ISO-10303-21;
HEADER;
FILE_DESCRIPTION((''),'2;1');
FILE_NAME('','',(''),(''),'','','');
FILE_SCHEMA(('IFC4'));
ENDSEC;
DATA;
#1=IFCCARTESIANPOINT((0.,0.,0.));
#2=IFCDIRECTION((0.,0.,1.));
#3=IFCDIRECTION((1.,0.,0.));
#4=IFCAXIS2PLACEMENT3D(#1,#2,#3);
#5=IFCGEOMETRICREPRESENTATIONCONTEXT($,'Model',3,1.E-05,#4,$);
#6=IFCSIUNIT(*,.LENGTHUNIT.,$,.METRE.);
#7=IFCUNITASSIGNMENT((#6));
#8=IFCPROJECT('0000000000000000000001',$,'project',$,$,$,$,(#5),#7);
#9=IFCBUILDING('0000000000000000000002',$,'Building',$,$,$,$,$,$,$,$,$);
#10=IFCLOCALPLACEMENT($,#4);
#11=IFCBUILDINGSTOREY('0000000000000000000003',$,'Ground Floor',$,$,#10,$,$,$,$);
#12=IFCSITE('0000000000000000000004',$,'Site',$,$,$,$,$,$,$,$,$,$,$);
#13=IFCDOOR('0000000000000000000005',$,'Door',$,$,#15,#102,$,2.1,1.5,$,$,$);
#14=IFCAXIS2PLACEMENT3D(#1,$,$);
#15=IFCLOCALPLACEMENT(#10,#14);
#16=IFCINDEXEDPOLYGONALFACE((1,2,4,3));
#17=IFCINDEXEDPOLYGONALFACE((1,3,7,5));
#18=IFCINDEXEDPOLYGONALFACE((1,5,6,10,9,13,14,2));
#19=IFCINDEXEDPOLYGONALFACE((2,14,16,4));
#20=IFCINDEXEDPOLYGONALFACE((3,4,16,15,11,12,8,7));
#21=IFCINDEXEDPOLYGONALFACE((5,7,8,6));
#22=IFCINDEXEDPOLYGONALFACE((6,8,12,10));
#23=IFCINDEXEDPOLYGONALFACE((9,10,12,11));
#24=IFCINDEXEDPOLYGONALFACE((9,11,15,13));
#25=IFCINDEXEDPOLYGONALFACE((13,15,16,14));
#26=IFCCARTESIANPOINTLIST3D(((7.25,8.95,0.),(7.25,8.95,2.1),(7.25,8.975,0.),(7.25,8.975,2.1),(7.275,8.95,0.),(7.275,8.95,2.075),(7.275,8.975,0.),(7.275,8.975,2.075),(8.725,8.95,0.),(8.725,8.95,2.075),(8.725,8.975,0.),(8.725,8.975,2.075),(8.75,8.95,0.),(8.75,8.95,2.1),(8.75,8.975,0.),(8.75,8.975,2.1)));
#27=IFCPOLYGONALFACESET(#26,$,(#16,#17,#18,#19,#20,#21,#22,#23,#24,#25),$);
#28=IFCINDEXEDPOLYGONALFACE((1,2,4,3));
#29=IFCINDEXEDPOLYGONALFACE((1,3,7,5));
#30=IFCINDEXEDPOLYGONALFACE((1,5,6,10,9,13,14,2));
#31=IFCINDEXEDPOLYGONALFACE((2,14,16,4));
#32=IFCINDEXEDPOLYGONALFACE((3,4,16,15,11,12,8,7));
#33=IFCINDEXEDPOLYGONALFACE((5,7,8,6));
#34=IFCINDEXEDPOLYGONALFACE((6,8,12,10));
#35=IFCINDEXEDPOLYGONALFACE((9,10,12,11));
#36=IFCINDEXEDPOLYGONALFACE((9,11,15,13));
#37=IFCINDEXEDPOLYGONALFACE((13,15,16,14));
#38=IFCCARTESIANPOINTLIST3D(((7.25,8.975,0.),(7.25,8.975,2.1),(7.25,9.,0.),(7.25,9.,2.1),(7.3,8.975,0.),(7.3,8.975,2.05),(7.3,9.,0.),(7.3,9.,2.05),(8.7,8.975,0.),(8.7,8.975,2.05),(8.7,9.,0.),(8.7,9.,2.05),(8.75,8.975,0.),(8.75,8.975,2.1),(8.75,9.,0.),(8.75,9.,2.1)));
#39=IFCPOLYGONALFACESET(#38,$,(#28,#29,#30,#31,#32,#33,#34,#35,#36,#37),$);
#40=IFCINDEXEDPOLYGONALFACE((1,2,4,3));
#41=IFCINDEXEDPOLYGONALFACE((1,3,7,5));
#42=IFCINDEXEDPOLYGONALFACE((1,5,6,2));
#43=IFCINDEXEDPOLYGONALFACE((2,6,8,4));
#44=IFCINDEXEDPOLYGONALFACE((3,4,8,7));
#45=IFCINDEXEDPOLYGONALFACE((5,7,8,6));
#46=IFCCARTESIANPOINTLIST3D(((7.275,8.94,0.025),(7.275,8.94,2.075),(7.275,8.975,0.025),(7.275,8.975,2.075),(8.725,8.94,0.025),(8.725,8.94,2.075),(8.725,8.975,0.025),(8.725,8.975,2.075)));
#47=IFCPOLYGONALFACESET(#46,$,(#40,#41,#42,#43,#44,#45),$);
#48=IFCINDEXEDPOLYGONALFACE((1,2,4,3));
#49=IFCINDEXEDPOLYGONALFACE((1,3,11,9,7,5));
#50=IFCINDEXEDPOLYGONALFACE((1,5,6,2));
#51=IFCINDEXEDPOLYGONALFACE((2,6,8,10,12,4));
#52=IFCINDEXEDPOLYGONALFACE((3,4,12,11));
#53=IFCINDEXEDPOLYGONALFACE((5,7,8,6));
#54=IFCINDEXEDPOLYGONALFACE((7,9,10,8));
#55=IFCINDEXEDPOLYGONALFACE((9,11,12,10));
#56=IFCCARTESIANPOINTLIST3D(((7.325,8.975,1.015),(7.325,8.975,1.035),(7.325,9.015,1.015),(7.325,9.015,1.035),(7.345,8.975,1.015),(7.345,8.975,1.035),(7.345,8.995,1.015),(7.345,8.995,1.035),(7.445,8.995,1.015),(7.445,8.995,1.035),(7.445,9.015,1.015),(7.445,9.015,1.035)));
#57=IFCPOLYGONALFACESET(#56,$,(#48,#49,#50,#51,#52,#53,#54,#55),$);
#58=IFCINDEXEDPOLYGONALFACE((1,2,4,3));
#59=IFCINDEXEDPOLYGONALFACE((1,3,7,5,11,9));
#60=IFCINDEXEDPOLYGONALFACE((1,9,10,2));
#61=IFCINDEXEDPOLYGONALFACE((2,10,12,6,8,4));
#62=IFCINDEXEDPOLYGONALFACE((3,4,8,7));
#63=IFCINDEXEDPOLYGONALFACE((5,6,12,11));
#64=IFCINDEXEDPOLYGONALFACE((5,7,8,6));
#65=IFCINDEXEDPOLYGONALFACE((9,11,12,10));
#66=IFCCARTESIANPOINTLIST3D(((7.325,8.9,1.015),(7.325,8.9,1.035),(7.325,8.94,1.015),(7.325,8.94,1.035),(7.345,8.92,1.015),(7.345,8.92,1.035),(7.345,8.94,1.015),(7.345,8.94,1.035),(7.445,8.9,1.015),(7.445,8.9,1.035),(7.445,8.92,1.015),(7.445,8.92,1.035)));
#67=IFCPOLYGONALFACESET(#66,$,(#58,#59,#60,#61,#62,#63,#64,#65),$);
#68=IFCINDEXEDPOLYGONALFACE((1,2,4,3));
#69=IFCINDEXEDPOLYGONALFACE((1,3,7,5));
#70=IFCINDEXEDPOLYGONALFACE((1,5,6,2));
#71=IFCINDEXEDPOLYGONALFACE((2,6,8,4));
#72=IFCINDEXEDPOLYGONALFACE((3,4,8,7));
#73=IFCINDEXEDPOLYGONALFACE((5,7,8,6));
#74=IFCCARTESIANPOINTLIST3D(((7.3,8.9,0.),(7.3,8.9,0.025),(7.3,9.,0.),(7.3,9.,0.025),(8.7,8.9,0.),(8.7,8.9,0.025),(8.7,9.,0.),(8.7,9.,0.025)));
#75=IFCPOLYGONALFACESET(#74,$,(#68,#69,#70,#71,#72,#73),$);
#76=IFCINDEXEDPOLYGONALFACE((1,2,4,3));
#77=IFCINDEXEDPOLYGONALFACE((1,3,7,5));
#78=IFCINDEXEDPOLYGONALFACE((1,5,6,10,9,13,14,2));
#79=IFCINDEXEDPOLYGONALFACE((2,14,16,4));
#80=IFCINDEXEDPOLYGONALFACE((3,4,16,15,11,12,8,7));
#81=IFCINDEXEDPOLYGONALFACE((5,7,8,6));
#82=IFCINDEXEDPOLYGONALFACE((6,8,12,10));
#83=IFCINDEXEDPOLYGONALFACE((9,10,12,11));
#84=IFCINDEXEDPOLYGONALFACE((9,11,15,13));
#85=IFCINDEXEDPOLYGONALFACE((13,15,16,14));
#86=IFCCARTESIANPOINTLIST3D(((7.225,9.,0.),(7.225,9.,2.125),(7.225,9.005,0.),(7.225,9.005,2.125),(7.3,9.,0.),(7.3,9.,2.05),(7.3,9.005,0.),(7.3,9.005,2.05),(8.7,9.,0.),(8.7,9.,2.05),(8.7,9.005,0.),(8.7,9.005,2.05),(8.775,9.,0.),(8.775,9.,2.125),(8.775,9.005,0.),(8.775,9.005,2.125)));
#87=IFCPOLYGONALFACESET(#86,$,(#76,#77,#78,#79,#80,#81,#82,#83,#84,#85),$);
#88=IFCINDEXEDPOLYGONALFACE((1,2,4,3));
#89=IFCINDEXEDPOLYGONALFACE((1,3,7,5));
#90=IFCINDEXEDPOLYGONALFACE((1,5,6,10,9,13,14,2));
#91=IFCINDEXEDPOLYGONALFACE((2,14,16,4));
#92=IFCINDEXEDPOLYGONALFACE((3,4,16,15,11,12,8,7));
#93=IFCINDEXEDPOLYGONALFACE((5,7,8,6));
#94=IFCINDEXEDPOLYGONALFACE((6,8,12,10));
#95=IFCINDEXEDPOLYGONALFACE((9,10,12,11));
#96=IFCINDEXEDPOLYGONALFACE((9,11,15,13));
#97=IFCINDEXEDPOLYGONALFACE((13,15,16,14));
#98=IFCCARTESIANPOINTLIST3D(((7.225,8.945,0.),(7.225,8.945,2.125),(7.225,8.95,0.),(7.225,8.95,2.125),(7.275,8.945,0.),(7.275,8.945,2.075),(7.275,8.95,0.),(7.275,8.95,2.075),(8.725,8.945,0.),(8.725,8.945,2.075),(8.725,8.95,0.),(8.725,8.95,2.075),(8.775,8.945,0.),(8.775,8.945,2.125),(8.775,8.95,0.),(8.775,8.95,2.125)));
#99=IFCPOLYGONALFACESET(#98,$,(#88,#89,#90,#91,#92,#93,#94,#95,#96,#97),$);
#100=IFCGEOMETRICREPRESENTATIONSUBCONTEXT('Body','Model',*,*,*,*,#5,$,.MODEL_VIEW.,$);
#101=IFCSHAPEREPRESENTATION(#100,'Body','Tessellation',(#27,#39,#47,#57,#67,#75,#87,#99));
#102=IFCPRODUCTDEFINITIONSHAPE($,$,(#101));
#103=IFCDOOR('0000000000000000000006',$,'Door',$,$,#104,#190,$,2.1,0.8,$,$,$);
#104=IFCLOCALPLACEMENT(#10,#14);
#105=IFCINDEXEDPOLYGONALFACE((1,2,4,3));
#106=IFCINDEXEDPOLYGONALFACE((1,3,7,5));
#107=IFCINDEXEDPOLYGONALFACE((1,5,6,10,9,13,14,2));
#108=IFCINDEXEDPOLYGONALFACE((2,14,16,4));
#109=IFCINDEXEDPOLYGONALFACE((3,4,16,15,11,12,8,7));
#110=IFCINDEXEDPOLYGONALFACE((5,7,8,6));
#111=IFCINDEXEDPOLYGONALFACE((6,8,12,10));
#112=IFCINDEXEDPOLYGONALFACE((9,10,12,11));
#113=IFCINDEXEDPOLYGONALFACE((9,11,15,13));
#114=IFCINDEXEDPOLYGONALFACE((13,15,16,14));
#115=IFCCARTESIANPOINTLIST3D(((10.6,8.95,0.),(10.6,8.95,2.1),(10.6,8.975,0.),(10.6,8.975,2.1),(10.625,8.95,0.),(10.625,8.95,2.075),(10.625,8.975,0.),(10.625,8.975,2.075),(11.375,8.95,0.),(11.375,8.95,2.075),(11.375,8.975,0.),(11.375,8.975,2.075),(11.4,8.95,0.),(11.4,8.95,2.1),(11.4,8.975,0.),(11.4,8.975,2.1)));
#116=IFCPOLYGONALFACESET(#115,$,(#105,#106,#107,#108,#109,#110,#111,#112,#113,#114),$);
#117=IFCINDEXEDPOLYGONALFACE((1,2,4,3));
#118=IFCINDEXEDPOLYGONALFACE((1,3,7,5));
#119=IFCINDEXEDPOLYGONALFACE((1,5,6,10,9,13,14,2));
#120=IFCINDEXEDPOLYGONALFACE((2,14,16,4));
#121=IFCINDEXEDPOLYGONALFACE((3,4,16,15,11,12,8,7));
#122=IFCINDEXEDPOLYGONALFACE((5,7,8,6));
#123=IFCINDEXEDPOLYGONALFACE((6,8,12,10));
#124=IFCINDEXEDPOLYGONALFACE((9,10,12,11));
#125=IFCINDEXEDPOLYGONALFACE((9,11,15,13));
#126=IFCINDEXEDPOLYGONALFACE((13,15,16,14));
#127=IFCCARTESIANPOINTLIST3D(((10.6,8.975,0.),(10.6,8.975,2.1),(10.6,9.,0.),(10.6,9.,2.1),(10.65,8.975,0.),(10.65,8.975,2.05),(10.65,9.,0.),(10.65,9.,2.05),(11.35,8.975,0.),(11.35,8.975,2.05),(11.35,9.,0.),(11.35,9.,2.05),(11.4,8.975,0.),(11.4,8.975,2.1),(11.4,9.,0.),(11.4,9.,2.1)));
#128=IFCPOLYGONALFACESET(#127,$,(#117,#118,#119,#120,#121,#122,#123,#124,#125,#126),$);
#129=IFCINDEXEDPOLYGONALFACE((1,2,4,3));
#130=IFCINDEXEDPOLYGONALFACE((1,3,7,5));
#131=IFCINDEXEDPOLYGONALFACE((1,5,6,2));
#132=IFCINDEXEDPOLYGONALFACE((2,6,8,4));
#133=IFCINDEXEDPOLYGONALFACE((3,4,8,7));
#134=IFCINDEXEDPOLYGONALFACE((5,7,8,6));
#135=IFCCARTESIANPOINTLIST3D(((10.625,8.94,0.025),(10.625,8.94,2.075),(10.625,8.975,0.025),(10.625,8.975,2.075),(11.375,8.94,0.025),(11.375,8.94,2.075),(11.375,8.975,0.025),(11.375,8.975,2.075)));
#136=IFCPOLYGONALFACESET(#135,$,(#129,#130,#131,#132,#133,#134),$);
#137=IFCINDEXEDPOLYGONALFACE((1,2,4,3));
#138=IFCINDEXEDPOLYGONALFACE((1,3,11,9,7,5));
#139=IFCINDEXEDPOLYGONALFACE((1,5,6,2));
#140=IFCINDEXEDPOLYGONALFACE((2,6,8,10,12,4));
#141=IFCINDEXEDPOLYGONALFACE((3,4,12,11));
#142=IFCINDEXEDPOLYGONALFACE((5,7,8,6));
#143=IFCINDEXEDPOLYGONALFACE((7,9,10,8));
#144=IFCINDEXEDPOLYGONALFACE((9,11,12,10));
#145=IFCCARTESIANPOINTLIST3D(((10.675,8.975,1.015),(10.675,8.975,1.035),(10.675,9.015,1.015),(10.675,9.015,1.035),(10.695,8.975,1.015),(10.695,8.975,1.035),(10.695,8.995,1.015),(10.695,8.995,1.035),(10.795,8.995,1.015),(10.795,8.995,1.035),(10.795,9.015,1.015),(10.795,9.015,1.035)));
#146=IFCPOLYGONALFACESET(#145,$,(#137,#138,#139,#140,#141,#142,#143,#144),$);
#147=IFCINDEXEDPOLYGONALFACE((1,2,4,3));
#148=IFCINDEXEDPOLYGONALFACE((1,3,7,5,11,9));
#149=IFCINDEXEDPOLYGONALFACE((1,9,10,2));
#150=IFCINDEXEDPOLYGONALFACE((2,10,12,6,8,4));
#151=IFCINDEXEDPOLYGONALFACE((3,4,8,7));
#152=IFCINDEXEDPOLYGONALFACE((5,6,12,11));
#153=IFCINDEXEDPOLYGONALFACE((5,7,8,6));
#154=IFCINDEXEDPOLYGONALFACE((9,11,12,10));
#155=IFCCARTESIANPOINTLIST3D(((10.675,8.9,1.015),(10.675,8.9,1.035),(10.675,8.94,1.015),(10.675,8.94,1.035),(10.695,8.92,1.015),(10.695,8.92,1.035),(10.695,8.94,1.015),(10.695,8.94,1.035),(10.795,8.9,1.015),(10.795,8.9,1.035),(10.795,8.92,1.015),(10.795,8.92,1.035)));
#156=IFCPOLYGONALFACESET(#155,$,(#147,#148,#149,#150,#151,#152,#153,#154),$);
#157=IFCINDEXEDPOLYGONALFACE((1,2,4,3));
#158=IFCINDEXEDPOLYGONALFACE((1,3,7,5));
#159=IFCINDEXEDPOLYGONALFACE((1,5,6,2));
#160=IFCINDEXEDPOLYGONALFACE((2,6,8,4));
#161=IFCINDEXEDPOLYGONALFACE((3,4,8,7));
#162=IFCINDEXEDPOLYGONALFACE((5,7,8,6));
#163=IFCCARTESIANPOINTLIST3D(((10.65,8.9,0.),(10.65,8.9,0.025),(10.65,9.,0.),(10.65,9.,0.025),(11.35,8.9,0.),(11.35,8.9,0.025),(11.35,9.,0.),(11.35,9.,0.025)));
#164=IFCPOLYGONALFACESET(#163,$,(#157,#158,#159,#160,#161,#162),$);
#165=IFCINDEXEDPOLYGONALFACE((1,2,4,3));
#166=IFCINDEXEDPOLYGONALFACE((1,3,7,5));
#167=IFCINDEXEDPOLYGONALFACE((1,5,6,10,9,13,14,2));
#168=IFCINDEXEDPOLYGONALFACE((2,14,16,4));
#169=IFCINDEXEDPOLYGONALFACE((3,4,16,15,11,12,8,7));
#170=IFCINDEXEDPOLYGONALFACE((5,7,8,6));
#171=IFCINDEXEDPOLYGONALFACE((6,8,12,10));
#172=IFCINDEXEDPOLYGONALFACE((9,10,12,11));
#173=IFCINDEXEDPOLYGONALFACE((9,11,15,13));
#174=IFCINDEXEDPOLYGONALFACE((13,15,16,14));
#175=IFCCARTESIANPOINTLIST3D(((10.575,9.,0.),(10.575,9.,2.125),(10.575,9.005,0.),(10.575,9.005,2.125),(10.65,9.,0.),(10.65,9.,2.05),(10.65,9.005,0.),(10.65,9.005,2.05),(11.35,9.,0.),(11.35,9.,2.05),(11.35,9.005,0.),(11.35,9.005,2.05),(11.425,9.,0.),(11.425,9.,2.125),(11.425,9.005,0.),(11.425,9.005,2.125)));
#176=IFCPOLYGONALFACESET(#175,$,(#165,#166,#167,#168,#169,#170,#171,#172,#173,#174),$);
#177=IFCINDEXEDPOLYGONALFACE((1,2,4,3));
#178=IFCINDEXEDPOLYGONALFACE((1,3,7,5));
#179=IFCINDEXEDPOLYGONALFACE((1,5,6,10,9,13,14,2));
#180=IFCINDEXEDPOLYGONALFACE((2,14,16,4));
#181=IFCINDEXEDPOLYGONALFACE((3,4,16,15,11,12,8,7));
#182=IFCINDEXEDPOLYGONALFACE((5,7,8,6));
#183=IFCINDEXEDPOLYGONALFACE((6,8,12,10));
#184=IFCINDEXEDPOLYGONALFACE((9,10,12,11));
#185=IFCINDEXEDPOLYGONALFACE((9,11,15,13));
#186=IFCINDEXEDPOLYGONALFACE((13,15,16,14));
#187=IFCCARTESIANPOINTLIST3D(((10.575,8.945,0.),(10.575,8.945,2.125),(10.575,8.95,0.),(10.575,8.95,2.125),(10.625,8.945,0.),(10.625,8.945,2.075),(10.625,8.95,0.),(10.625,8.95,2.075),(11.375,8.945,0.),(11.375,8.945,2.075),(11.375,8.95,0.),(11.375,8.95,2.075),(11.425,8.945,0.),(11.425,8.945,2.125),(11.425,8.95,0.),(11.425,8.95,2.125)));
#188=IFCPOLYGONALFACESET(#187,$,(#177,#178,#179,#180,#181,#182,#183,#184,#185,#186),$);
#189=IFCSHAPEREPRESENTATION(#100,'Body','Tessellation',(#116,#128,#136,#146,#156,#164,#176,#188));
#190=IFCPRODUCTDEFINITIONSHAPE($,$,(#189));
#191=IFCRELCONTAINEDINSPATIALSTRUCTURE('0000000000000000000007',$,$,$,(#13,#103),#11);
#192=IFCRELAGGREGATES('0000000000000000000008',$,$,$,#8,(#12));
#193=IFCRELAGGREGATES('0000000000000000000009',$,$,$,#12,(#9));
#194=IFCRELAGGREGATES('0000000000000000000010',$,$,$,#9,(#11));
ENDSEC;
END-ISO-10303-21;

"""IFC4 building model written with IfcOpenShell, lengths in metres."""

from ifc_helpers import new_model, si_unit, frame, origin_with_axes, place, context, subcontext, project, spatial, line, indexed_curve, outline, extrude, element, save


model = new_model("IFC4")

# Units and contexts
model_context = context("Model", 3, precision=1e-05, world=origin_with_axes())
body_context = subcontext(model_context, "Body", "Model", "MODEL_VIEW")
ifc_project = project(units=[si_unit("LENGTHUNIT", "METRE")], contexts=[model_context])

# Site, building, storey
site = spatial("IfcSite", under=ifc_project, Name="Site")
building = spatial("IfcBuilding", under=site, Name="Building")
storey_placement = place(None, origin_with_axes())
storey = spatial("IfcBuildingStorey", under=building, at=storey_placement, Name="Ground Floor")

# Doors
door_1_placement = place(storey_placement, frame((8.75, 9.0, 0.0), z_axis=(0.0, 0.0, 1.0), x_axis=(-1.0, 0.0, 0.0)))
element("IfcDoor", 1, at=door_1_placement, inside=storey, Name="Door", OverallHeight=2.1, OverallWidth=1.5, context=body_context, shape_type="SweptSolid", body=[
    extrude(outline(indexed_curve([(0.0, 0.0), (0.0, 2.1), (1.5, 2.1), (1.5, 0.0), (1.475, 0.0), (1.475, 2.075), (0.025, 2.075), (0.025, 0.0)], segments=[line(1, 2, 3, 4, 5, 6, 7, 8, 1)])), frame((0.0, 0.025, 0.0), z_axis=(0.0, -1.0, 0.0), x_axis=(1.0, 0.0, 0.0)), (0.0, 0.0, -1.0), 0.025),
    extrude(outline(indexed_curve([(0.0, 0.0), (0.0, 2.1), (1.5, 2.1), (1.5, 0.0), (1.45, 0.0), (1.45, 2.05), (0.05, 2.05), (0.05, 0.0)], segments=[line(1, 2, 3, 4, 5, 6, 7, 8, 1)])), frame((0.0, 0.0, 0.0), z_axis=(0.0, -1.0, 0.0), x_axis=(1.0, 0.0, 0.0)), (0.0, 0.0, -1.0), 0.025),
    extrude(outline(indexed_curve([(0.0, 0.0), (1.45, 0.0), (1.45, 0.035), (0.0, 0.035)], segments=[line(1, 2, 3, 4, 1)])), frame((0.025, 0.025, 0.025), z_axis=(0.0, 0.0, 1.0), x_axis=(1.0, 0.0, 0.0)), (0.0, 0.0, 1.0), 2.05),
    extrude(outline(indexed_curve([(0.0, 0.0), (0.0, -0.04), (-0.12, -0.04), (-0.12, -0.02), (-0.02, -0.02), (-0.02, 0.0)], segments=[line(1, 2, 3, 4, 5, 6, 1)])), frame((1.425, 0.025, 1.015), z_axis=(0.0, 0.0, 1.0), x_axis=(1.0, 0.0, 0.0)), (0.0, 0.0, 1.0), 0.02),
    extrude(outline(indexed_curve([(0.0, 0.0), (0.0, 0.04), (-0.12, 0.04), (-0.12, 0.02), (-0.02, 0.02), (-0.02, 0.0)], segments=[line(1, 2, 3, 4, 5, 6, 1)])), frame((1.425, 0.06, 1.015), z_axis=(0.0, 0.0, 1.0), x_axis=(1.0, 0.0, 0.0)), (0.0, 0.0, 1.0), 0.02),
    extrude(outline(indexed_curve([(0.0, 0.0), (1.4, 0.0), (1.4, 0.1), (0.0, 0.1)], segments=[line(1, 2, 3, 4, 1)])), frame((0.05, 0.0, 0.0), z_axis=(0.0, 0.0, 1.0), x_axis=(1.0, 0.0, 0.0)), (0.0, 0.0, 1.0), 0.025),
    extrude(outline(indexed_curve([(0.0, 0.0), (0.0, 2.125), (1.55, 2.125), (1.55, 0.0), (1.475, 0.0), (1.475, 2.05), (0.075, 2.05), (0.075, 0.0)], segments=[line(1, 2, 3, 4, 5, 6, 7, 8, 1)])), frame((-0.025, -0.005, 0.0), z_axis=(0.0, -1.0, 0.0), x_axis=(1.0, 0.0, 0.0)), (0.0, 0.0, -1.0), 0.005),
    extrude(outline(indexed_curve([(0.0, 0.0), (0.0, 2.125), (1.55, 2.125), (1.55, 0.0), (1.5, 0.0), (1.5, 2.075), (0.05, 2.075), (0.05, 0.0)], segments=[line(1, 2, 3, 4, 5, 6, 7, 8, 1)])), frame((-0.025, 0.05, 0.0), z_axis=(0.0, -1.0, 0.0), x_axis=(1.0, 0.0, 0.0)), (0.0, 0.0, -1.0), 0.005),
])
door_2_placement = place(storey_placement, frame((11.4, 9.0, 0.0), z_axis=(0.0, 0.0, 1.0), x_axis=(-1.0, 0.0, 0.0)))
element("IfcDoor", 2, at=door_2_placement, inside=storey, Name="Door", OverallHeight=2.1, OverallWidth=0.8, context=body_context, shape_type="SweptSolid", body=[
    extrude(outline(indexed_curve([(0.0, 0.0), (0.0, 2.1), (0.8, 2.1), (0.8, 0.0), (0.775, 0.0), (0.775, 2.075), (0.025, 2.075), (0.025, 0.0)], segments=[line(1, 2, 3, 4, 5, 6, 7, 8, 1)])), frame((0.0, 0.025, 0.0), z_axis=(0.0, -1.0, 0.0), x_axis=(1.0, 0.0, 0.0)), (0.0, 0.0, -1.0), 0.025),
    extrude(outline(indexed_curve([(0.0, 0.0), (0.0, 2.1), (0.8, 2.1), (0.8, 0.0), (0.75, 0.0), (0.75, 2.05), (0.05, 2.05), (0.05, 0.0)], segments=[line(1, 2, 3, 4, 5, 6, 7, 8, 1)])), frame((0.0, 0.0, 0.0), z_axis=(0.0, -1.0, 0.0), x_axis=(1.0, 0.0, 0.0)), (0.0, 0.0, -1.0), 0.025),
    extrude(outline(indexed_curve([(0.0, 0.0), (0.75, 0.0), (0.75, 0.035), (0.0, 0.035)], segments=[line(1, 2, 3, 4, 1)])), frame((0.025, 0.025, 0.025), z_axis=(0.0, 0.0, 1.0), x_axis=(1.0, 0.0, 0.0)), (0.0, 0.0, 1.0), 2.05),
    extrude(outline(indexed_curve([(0.0, 0.0), (0.0, -0.04), (-0.12, -0.04), (-0.12, -0.02), (-0.02, -0.02), (-0.02, 0.0)], segments=[line(1, 2, 3, 4, 5, 6, 1)])), frame((0.725, 0.025, 1.015), z_axis=(0.0, 0.0, 1.0), x_axis=(1.0, 0.0, 0.0)), (0.0, 0.0, 1.0), 0.02),
    extrude(outline(indexed_curve([(0.0, 0.0), (0.0, 0.04), (-0.12, 0.04), (-0.12, 0.02), (-0.02, 0.02), (-0.02, 0.0)], segments=[line(1, 2, 3, 4, 5, 6, 1)])), frame((0.725, 0.06, 1.015), z_axis=(0.0, 0.0, 1.0), x_axis=(1.0, 0.0, 0.0)), (0.0, 0.0, 1.0), 0.02),
    extrude(outline(indexed_curve([(0.0, 0.0), (0.7, 0.0), (0.7, 0.1), (0.0, 0.1)], segments=[line(1, 2, 3, 4, 1)])), frame((0.05, 0.0, 0.0), z_axis=(0.0, 0.0, 1.0), x_axis=(1.0, 0.0, 0.0)), (0.0, 0.0, 1.0), 0.025),
    extrude(outline(indexed_curve([(0.0, 0.0), (0.0, 2.125), (0.85, 2.125), (0.85, 0.0), (0.775, 0.0), (0.775, 2.05), (0.075, 2.05), (0.075, 0.0)], segments=[line(1, 2, 3, 4, 5, 6, 7, 8, 1)])), frame((-0.025, -0.005, 0.0), z_axis=(0.0, -1.0, 0.0), x_axis=(1.0, 0.0, 0.0)), (0.0, 0.0, -1.0), 0.005),
    extrude(outline(indexed_curve([(0.0, 0.0), (0.0, 2.125), (0.85, 2.125), (0.85, 0.0), (0.8, 0.0), (0.8, 2.075), (0.05, 2.075), (0.05, 0.0)], segments=[line(1, 2, 3, 4, 5, 6, 7, 8, 1)])), frame((-0.025, 0.05, 0.0), z_axis=(0.0, -1.0, 0.0), x_axis=(1.0, 0.0, 0.0)), (0.0, 0.0, -1.0), 0.005),
])

save(model, "model.ifc")
